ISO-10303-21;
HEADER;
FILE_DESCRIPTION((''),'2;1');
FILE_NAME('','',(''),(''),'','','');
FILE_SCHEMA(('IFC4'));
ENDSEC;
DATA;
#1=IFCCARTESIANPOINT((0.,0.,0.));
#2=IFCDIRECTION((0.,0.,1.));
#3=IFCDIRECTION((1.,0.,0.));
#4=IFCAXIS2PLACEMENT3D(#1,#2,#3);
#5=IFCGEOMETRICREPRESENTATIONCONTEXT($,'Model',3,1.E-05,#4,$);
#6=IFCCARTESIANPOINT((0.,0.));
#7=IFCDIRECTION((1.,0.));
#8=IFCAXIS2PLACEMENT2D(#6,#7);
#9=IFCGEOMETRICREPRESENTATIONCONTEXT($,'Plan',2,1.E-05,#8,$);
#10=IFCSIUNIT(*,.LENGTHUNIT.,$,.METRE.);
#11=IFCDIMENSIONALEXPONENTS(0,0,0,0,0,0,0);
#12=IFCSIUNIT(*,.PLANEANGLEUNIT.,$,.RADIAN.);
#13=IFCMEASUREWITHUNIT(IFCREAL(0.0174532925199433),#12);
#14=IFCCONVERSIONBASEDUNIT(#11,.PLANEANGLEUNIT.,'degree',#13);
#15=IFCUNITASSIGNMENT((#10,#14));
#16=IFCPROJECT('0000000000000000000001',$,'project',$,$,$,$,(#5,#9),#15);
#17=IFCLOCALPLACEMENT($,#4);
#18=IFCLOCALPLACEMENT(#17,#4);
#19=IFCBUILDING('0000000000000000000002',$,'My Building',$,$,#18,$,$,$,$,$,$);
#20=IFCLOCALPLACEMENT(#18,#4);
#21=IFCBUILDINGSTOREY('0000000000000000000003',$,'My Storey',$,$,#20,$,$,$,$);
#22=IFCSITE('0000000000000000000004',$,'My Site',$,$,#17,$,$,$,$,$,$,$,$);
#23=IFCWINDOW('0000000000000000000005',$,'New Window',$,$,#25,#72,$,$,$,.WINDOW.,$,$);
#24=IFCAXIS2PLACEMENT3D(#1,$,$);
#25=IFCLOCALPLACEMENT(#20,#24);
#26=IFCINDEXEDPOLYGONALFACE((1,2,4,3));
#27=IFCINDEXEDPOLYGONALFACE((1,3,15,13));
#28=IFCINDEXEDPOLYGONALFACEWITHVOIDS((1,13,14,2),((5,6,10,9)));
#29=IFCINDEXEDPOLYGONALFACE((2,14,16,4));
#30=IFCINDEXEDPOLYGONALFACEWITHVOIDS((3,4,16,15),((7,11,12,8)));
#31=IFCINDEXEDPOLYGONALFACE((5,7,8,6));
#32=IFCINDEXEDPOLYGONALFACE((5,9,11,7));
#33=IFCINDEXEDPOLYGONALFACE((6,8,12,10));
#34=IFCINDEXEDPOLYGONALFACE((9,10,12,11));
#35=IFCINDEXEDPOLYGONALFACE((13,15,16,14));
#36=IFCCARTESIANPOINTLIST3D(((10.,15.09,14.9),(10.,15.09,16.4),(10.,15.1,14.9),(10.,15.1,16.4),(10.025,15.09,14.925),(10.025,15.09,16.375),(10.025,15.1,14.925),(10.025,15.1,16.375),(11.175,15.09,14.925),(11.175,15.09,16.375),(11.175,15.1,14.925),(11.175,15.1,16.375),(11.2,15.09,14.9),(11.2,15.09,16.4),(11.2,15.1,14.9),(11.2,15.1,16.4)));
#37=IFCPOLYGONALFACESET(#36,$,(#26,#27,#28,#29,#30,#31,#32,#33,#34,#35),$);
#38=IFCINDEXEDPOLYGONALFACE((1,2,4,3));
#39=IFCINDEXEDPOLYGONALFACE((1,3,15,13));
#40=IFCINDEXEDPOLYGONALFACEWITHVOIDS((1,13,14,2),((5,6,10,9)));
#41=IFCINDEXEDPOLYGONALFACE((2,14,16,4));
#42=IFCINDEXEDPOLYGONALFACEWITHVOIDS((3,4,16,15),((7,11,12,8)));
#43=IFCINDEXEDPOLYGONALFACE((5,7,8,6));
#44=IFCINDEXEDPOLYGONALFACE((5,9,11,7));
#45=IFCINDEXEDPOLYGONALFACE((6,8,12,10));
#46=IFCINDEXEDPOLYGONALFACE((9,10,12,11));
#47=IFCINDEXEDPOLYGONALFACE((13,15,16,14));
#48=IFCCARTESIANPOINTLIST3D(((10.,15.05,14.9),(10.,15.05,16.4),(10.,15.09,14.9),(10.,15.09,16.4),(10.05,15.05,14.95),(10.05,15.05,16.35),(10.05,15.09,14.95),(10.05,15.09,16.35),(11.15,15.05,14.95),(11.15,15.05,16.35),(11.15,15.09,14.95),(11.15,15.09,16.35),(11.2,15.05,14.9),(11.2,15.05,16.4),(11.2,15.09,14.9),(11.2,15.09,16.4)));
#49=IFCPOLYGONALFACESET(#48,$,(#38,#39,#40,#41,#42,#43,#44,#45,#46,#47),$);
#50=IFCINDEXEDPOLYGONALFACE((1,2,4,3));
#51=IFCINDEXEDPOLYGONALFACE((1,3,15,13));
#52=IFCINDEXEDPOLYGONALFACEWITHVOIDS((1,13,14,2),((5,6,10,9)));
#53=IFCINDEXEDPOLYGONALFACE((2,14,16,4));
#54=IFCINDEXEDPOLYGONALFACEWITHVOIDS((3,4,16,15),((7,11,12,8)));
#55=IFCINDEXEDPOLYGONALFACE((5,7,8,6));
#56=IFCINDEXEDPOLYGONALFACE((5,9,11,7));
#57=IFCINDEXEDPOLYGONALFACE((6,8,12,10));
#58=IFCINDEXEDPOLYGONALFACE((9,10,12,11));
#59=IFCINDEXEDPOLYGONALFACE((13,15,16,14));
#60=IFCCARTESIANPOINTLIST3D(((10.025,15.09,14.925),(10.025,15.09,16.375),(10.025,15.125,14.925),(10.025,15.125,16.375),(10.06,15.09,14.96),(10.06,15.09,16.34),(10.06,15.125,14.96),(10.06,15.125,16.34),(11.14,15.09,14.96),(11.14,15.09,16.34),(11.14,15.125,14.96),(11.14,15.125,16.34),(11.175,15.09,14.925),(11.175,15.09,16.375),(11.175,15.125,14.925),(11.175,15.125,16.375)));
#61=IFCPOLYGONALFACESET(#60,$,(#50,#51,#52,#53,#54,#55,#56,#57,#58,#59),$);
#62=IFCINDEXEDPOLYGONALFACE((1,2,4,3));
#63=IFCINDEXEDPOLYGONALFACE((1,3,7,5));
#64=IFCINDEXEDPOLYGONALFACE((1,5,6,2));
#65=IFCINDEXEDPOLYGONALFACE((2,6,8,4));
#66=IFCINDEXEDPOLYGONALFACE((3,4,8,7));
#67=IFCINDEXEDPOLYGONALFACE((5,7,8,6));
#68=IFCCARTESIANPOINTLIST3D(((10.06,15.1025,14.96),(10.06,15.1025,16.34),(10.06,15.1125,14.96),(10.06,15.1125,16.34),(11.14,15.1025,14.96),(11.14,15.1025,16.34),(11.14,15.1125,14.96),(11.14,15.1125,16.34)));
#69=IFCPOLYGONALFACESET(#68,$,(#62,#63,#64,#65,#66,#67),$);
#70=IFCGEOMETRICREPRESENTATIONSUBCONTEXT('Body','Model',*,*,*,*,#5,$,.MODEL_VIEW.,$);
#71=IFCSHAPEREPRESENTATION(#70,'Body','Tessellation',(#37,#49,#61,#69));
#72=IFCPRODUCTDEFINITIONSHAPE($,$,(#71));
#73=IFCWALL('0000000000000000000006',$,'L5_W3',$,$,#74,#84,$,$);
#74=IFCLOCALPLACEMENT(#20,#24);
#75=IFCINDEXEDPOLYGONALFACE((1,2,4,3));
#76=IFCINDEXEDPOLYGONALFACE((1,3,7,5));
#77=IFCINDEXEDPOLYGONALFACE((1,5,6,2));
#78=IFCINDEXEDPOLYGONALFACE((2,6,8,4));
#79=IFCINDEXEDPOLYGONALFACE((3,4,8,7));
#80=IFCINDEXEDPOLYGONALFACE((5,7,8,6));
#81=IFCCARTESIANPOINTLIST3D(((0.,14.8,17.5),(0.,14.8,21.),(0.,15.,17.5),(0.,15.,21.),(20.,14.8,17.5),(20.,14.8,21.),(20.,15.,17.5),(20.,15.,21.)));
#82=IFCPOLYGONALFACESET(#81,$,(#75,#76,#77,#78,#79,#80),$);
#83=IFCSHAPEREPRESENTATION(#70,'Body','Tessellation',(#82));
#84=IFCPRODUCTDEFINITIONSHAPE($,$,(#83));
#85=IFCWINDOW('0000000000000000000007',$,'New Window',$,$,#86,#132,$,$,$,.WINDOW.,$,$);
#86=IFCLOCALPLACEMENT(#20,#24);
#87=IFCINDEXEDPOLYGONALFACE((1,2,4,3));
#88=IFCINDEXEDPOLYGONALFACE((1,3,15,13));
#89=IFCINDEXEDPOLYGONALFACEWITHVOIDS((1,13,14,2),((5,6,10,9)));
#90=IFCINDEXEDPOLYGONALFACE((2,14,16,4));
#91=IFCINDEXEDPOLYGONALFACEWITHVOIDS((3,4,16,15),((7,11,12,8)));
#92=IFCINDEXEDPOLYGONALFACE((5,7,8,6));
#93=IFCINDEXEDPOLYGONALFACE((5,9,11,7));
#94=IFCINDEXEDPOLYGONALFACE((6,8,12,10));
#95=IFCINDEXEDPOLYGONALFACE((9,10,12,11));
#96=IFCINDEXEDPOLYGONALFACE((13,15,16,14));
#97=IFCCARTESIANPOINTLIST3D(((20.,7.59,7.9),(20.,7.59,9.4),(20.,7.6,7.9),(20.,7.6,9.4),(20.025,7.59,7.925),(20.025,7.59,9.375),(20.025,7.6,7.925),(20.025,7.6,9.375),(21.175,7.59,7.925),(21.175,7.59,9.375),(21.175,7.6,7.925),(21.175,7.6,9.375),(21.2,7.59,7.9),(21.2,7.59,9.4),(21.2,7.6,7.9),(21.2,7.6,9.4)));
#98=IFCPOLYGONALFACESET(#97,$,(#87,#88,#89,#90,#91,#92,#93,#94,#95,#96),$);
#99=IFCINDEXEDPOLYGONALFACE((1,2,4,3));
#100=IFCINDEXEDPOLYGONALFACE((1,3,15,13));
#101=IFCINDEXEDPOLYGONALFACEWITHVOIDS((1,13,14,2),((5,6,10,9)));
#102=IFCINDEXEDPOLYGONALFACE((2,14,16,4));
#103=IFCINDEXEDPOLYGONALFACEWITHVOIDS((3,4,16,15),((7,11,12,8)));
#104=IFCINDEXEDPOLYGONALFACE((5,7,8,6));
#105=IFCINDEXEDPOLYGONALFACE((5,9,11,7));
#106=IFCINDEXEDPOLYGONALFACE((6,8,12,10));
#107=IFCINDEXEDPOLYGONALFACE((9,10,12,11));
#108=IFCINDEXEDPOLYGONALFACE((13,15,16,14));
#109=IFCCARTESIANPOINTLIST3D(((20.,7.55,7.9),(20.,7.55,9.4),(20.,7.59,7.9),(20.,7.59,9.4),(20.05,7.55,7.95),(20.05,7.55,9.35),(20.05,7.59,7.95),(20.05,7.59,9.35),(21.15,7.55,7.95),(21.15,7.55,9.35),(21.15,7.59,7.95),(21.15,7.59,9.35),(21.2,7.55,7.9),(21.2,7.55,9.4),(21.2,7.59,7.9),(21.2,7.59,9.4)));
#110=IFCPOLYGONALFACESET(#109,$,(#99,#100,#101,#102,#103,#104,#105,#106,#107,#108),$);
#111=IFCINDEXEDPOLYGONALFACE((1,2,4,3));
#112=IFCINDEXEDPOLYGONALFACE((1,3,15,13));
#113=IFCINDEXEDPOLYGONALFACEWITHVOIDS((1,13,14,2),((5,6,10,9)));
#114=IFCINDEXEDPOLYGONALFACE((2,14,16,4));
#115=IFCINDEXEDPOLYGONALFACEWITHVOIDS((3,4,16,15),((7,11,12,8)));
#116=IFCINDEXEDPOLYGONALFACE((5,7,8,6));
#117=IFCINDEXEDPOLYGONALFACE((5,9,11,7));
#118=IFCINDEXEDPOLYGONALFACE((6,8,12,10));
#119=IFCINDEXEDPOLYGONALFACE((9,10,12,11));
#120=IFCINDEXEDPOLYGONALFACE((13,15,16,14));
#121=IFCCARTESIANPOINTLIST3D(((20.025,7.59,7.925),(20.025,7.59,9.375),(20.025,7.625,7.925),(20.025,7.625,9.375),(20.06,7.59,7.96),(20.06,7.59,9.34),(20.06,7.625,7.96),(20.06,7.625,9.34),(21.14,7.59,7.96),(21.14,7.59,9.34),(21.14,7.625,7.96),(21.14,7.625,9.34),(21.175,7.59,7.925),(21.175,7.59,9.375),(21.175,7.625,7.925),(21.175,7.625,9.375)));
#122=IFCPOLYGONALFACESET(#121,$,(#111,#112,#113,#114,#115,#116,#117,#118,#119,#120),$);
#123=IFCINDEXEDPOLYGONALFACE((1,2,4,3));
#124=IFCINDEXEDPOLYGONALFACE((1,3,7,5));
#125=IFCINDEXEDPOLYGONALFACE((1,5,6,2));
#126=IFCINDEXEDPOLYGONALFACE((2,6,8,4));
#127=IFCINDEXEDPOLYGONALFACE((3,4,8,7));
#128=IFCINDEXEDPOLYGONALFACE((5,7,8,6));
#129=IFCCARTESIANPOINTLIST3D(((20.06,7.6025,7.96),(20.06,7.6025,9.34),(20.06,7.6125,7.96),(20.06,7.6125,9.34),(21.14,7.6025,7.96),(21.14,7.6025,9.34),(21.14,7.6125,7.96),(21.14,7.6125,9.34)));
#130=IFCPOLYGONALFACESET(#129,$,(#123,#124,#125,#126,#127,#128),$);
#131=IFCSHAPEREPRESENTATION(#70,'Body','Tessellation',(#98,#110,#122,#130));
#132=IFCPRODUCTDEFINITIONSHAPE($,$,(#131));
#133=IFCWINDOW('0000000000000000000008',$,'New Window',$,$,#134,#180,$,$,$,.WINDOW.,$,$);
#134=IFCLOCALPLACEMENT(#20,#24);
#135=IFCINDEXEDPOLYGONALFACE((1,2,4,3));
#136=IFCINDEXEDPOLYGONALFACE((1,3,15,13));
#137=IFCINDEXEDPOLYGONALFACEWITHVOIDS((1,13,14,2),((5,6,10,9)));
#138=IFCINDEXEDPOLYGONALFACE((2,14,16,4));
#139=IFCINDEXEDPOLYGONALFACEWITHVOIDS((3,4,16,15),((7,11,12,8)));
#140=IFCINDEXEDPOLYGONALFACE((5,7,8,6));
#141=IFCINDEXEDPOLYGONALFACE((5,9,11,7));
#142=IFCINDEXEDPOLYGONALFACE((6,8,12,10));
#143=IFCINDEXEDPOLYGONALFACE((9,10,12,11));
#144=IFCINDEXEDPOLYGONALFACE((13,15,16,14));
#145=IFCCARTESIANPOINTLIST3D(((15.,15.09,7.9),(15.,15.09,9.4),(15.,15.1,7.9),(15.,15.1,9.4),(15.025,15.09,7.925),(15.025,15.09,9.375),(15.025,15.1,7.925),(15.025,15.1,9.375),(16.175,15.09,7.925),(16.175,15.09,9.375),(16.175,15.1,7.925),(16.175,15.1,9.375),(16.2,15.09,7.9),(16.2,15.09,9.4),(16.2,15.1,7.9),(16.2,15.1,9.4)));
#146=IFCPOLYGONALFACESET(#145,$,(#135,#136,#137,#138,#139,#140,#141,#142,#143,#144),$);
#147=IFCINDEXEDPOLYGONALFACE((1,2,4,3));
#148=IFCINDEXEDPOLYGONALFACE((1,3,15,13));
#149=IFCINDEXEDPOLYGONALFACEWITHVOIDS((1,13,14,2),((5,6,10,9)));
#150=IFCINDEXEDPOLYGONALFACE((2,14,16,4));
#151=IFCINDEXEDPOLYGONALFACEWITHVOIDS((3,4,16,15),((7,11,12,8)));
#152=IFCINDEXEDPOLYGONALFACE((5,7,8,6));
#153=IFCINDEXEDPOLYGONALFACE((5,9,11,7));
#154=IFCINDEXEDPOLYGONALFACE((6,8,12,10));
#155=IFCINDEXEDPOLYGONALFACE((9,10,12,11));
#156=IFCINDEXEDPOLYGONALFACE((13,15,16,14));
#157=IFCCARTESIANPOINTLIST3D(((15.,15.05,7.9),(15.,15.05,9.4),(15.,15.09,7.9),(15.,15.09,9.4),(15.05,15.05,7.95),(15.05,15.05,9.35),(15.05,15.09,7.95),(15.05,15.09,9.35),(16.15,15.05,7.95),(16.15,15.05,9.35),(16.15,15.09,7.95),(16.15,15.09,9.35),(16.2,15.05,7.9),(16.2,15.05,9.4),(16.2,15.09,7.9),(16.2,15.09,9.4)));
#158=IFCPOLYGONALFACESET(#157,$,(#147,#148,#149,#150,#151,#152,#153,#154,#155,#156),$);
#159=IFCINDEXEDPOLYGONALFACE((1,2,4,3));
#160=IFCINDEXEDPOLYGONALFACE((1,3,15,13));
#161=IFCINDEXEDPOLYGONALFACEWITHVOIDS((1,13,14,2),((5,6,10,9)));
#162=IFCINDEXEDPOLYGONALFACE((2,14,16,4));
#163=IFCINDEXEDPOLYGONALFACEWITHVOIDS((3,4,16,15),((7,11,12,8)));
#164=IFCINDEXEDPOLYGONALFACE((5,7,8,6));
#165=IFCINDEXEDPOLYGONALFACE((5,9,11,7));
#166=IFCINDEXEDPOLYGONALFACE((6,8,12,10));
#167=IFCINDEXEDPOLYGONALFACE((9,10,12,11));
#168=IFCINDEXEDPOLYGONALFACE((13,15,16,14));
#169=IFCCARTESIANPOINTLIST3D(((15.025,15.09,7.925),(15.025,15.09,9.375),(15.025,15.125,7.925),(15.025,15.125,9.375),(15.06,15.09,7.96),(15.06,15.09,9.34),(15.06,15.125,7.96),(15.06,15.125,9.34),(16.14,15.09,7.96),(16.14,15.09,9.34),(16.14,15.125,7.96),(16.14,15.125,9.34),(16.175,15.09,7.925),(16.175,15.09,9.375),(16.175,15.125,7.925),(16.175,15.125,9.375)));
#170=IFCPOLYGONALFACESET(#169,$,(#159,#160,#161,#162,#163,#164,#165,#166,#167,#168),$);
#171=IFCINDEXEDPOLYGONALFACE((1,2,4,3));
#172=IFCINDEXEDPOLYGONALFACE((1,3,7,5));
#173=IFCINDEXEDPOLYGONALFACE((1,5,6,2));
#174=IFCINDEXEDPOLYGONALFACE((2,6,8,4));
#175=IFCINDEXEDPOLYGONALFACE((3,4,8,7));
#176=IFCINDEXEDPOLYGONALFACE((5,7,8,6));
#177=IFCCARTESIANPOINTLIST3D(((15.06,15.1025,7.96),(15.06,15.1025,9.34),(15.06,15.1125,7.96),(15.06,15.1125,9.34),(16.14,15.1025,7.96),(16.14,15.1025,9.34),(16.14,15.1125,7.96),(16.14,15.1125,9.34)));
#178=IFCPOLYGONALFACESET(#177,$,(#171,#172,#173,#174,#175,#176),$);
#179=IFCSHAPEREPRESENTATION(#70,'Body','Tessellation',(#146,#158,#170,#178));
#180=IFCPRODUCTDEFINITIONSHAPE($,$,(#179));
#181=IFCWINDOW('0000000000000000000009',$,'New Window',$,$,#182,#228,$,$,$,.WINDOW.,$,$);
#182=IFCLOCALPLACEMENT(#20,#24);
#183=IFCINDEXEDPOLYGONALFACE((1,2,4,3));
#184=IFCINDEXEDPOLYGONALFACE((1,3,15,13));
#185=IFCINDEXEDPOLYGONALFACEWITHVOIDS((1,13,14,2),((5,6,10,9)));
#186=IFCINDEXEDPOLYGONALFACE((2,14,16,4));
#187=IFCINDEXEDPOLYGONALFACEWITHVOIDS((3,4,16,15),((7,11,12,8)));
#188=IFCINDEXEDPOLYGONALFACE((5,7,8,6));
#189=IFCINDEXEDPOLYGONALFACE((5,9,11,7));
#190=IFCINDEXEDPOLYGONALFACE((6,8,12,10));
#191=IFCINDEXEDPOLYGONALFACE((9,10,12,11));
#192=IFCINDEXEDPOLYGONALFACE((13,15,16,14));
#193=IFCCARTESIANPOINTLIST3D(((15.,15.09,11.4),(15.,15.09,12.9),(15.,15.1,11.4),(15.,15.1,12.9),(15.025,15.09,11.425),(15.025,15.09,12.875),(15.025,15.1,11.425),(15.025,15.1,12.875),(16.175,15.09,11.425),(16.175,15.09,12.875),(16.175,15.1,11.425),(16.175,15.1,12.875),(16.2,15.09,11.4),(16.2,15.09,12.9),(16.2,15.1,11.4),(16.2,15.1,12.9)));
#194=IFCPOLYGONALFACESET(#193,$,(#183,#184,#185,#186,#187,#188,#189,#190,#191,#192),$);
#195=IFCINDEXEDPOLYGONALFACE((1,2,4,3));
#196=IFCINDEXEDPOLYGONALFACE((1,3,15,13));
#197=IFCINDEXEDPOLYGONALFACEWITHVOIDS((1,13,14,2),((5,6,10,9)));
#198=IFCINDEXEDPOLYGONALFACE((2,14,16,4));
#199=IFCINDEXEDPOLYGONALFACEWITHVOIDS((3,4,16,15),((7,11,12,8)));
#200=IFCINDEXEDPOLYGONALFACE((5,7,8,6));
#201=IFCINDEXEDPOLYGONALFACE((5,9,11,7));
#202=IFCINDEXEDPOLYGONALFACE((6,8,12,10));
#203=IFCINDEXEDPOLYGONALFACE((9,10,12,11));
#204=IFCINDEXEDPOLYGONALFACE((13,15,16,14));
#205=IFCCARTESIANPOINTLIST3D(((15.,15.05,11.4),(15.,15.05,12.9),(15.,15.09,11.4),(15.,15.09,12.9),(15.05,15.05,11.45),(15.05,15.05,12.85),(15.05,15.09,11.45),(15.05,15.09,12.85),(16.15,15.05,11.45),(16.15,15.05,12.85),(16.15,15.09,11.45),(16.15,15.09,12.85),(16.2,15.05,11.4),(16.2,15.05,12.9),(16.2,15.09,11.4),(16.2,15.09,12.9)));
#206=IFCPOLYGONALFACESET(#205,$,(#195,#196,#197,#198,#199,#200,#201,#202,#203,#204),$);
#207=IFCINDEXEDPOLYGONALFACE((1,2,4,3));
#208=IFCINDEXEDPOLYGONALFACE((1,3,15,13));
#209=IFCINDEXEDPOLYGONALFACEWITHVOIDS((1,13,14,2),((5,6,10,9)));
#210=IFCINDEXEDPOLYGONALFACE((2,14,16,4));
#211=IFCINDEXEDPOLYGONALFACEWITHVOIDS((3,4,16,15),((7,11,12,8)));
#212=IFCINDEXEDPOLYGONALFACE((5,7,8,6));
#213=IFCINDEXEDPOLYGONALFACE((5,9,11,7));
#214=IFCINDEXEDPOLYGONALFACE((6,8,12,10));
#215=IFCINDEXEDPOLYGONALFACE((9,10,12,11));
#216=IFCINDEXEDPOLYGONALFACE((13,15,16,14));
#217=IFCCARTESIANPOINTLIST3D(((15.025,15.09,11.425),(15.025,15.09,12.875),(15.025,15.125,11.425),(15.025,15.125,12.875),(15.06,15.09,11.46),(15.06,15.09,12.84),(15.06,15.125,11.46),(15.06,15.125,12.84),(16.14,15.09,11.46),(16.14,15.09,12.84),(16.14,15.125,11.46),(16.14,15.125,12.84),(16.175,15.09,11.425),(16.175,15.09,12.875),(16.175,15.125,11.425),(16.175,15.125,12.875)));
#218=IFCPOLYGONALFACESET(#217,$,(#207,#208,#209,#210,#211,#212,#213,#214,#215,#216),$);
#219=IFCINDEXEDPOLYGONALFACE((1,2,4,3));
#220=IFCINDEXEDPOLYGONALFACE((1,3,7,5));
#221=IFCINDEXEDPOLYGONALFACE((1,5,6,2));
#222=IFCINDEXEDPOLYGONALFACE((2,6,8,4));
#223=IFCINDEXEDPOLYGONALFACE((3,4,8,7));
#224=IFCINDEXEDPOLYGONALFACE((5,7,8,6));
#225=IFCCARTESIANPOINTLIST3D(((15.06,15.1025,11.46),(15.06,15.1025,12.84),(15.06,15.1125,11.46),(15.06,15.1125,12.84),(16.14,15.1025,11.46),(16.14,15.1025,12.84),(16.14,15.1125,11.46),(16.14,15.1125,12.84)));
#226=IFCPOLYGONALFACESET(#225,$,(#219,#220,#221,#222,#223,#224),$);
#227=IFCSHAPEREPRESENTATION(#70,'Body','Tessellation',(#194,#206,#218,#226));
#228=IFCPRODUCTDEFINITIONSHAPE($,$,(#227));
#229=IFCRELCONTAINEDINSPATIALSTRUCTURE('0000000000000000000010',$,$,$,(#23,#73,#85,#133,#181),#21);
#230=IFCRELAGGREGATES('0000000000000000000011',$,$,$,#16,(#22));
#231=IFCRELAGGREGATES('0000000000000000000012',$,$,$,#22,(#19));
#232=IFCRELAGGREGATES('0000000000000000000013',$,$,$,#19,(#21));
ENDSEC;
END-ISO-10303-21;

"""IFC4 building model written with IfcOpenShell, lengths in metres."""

from ifc_helpers import new_model, entity, si_unit, converted_unit, frame, origin_with_axes, origin_2d_with_axis, place, context, subcontext, project, spatial, line, indexed_curve, outline, extrude, element, save


model = new_model("IFC4")

# Units and contexts
model_context = context("Model", 3, precision=1e-05, world=origin_with_axes())
plan_context = context("Plan", 2, precision=1e-05, world=origin_2d_with_axis())
body_context = subcontext(model_context, "Body", "Model", "MODEL_VIEW")
ifc_project = project(units=[si_unit("LENGTHUNIT", "METRE"), converted_unit("PLANEANGLEUNIT", "degree", entity("IfcReal", 0.0174532925199433), si_unit("PLANEANGLEUNIT", "RADIAN"), dimensions=[0, 0, 0, 0, 0, 0, 0])], contexts=[model_context, plan_context])

# Site, building, storey
site_placement = place(None, origin_with_axes())
site = spatial("IfcSite", under=ifc_project, at=site_placement, Name="My Site")
building_placement = place(site_placement, origin_with_axes())
building = spatial("IfcBuilding", under=site, at=building_placement, Name="My Building")
storey_placement = place(building_placement, origin_with_axes())
storey = spatial("IfcBuildingStorey", under=building, at=storey_placement, Name="My Storey")

# Window
for number, where, z_axis, x_axis, name in (
    (1, (10.0, 15.0, 14.9), (0.0, 0.0, 1.0), (1.0, 0.0, 0.0), "New Window"),
):
    element("IfcWindow", number, at=place(storey_placement, frame(where, z_axis=z_axis, x_axis=x_axis)), inside=storey, Name=name, PredefinedType="WINDOW", context=body_context, shape_type="SweptSolid", body=[
        extrude(outline(indexed_curve([(0.0, 0.0), (1.2, 0.0), (1.2, 1.5), (0.0, 1.5)], segments=[line(1, 2, 3, 4, 1)]), holes=[indexed_curve([(0.025, 0.025), (1.175, 0.025), (1.175, 1.475), (0.025, 1.475)], segments=[line(1, 2, 3, 4, 1)])]), frame((0.0, 0.09, 0.0), z_axis=(0.0, -1.0, 0.0), x_axis=(1.0, 0.0, 0.0)), (0.0, 0.0, -1.0), 0.01),
        extrude(outline(indexed_curve([(0.0, 0.0), (1.2, 0.0), (1.2, 1.5), (0.0, 1.5)], segments=[line(1, 2, 3, 4, 1)]), holes=[indexed_curve([(0.05, 0.05), (1.15, 0.05), (1.15, 1.45), (0.05, 1.45)], segments=[line(1, 2, 3, 4, 1)])]), frame((0.0, 0.05, 0.0), z_axis=(0.0, -1.0, 0.0), x_axis=(1.0, 0.0, 0.0)), (0.0, 0.0, -1.0), 0.04),
        extrude(outline(indexed_curve([(0.0, 0.0), (1.15, 0.0), (1.15, 1.45), (0.0, 1.45)], segments=[line(1, 2, 3, 4, 1)]), holes=[indexed_curve([(0.035, 0.035), (1.115, 0.035), (1.115, 1.415), (0.035, 1.415)], segments=[line(1, 2, 3, 4, 1)])]), frame((0.025, 0.09, 0.025), z_axis=(0.0, -1.0, 0.0), x_axis=(1.0, 0.0, 0.0)), (0.0, 0.0, -1.0), 0.035),
        extrude(outline(indexed_curve([(0.035, 0.035), (1.115, 0.035), (1.115, 1.415), (0.035, 1.415)], segments=[line(1, 2, 3, 4, 1)])), frame((0.025, 0.1025, 0.025), z_axis=(0.0, -1.0, 0.0), x_axis=(1.0, 0.0, 0.0)), (0.0, 0.0, -1.0), 0.01),
    ])

# Wall
for number, where, z_axis, x_axis, name in (
    (2, (20.0, 15.0, 17.5), (0.0, 0.0, 1.0), (-1.0, 0.0, 0.0), "L5_W3"),
):
    element("IfcWall", number, at=place(storey_placement, frame(where, z_axis=z_axis, x_axis=x_axis)), inside=storey, Name=name, context=body_context, shape_type="SweptSolid", body=[
        extrude(outline(indexed_curve([(0.0, 0.0), (0.0, 0.2), (20.0, 0.2), (20.0, 0.0), (0.0, 0.0)], self_intersect=False)), origin_with_axes(), (0.0, 0.0, 1.0), 3.5),
    ])

# Windows
for number, where, z_axis, x_axis, name in (
    (3, (20.0, 7.5, 7.9), (0.0, 0.0, 1.0), (1.0, 0.0, 0.0), "New Window"),
    (4, (15.0, 15.0, 7.9), (0.0, 0.0, 1.0), (1.0, 0.0, 0.0), "New Window"),
    (5, (15.0, 15.0, 11.4), (0.0, 0.0, 1.0), (1.0, 0.0, 0.0), "New Window"),
):
    element("IfcWindow", number, at=place(storey_placement, frame(where, z_axis=z_axis, x_axis=x_axis)), inside=storey, Name=name, PredefinedType="WINDOW", context=body_context, shape_type="SweptSolid", body=[
        extrude(outline(indexed_curve([(0.0, 0.0), (1.2, 0.0), (1.2, 1.5), (0.0, 1.5)], segments=[line(1, 2, 3, 4, 1)]), holes=[indexed_curve([(0.025, 0.025), (1.175, 0.025), (1.175, 1.475), (0.025, 1.475)], segments=[line(1, 2, 3, 4, 1)])]), frame((0.0, 0.09, 0.0), z_axis=(0.0, -1.0, 0.0), x_axis=(1.0, 0.0, 0.0)), (0.0, 0.0, -1.0), 0.01),
        extrude(outline(indexed_curve([(0.0, 0.0), (1.2, 0.0), (1.2, 1.5), (0.0, 1.5)], segments=[line(1, 2, 3, 4, 1)]), holes=[indexed_curve([(0.05, 0.05), (1.15, 0.05), (1.15, 1.45), (0.05, 1.45)], segments=[line(1, 2, 3, 4, 1)])]), frame((0.0, 0.05, 0.0), z_axis=(0.0, -1.0, 0.0), x_axis=(1.0, 0.0, 0.0)), (0.0, 0.0, -1.0), 0.04),
        extrude(outline(indexed_curve([(0.0, 0.0), (1.15, 0.0), (1.15, 1.45), (0.0, 1.45)], segments=[line(1, 2, 3, 4, 1)]), holes=[indexed_curve([(0.035, 0.035), (1.115, 0.035), (1.115, 1.415), (0.035, 1.415)], segments=[line(1, 2, 3, 4, 1)])]), frame((0.025, 0.09, 0.025), z_axis=(0.0, -1.0, 0.0), x_axis=(1.0, 0.0, 0.0)), (0.0, 0.0, -1.0), 0.035),
        extrude(outline(indexed_curve([(0.035, 0.035), (1.115, 0.035), (1.115, 1.415), (0.035, 1.415)], segments=[line(1, 2, 3, 4, 1)])), frame((0.025, 0.1025, 0.025), z_axis=(0.0, -1.0, 0.0), x_axis=(1.0, 0.0, 0.0)), (0.0, 0.0, -1.0), 0.01),
    ])

save(model, "model.ifc")
